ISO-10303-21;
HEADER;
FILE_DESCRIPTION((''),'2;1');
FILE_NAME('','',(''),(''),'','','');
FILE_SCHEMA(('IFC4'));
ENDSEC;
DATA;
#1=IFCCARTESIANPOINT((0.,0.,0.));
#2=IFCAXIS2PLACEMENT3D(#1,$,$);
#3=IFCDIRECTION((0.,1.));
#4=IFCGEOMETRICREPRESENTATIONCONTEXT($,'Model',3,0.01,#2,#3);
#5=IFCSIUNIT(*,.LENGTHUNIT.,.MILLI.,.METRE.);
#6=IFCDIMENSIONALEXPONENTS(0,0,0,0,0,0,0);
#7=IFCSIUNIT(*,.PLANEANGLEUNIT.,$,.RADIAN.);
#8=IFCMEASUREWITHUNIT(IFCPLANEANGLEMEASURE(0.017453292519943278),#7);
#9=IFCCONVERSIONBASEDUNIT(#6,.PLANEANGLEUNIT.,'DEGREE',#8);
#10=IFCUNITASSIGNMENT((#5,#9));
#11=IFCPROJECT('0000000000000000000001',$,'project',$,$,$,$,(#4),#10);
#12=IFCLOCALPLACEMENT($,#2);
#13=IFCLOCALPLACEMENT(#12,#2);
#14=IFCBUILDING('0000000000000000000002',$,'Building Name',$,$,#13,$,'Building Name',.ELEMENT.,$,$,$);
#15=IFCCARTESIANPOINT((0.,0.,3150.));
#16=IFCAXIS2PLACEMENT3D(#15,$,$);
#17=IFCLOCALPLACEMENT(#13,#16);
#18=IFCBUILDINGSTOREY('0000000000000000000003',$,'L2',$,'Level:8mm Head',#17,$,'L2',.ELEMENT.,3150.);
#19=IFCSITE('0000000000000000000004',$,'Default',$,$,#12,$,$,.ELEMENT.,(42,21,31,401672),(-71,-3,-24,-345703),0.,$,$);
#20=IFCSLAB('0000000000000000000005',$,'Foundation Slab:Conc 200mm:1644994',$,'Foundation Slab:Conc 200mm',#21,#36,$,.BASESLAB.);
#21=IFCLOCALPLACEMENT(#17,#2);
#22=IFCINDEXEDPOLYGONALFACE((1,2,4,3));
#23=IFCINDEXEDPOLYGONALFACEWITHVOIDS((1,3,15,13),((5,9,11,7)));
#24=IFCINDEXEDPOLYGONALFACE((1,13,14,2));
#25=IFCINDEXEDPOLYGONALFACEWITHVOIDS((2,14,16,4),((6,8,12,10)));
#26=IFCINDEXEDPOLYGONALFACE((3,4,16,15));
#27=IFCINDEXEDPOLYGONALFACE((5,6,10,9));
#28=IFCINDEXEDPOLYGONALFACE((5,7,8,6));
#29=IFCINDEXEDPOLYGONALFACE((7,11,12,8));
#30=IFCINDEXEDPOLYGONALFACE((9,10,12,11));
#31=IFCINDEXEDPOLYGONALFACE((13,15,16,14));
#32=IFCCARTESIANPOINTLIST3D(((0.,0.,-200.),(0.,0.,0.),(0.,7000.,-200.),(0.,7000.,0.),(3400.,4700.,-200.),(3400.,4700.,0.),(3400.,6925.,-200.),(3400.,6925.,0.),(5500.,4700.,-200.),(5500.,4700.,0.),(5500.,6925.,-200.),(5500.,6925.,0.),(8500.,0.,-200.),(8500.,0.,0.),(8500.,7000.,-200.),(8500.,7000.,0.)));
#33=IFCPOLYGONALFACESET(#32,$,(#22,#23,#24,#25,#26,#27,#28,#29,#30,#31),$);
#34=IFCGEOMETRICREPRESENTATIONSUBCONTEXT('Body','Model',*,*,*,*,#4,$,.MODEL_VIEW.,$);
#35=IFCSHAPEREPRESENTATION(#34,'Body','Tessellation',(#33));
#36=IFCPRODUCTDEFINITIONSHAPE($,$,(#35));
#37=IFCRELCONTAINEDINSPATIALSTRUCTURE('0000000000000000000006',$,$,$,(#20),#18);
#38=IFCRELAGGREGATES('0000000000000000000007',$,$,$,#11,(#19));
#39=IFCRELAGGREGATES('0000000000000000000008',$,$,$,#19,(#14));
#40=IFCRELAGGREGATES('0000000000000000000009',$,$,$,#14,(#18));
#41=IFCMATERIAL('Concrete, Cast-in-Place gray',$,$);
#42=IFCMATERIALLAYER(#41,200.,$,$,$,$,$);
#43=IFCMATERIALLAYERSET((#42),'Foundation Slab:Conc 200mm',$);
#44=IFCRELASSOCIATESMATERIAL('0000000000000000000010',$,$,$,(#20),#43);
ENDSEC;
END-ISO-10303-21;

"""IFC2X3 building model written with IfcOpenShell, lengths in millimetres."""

from ifc_helpers import new_model, entity, si_unit, converted_unit, direction, frame, frame_2d, origin, origin_2d_with_axis, place, context, subcontext, project, spatial, rectangle, extrude, material, layer, layer_set, layer_usage, element, save


model = new_model("IFC2X3")

# Units and contexts
model_context = context("Model", 3, precision=0.01, world=origin(), true_north=direction((0.0, 1.0)))
body_context = subcontext(model_context, "Body", "Model", "MODEL_VIEW")
ifc_project = project(units=[si_unit("LENGTHUNIT", "METRE", prefix="MILLI"), converted_unit("PLANEANGLEUNIT", "DEGREE", entity("IfcPlaneAngleMeasure", 0.017453292519943278), si_unit("PLANEANGLEUNIT", "RADIAN"), dimensions=[0, 0, 0, 0, 0, 0, 0])], contexts=[model_context])

# Site, building, storey
site_placement = place(None, origin())
site = spatial("IfcSite", under=ifc_project, at=site_placement, Name="Default", CompositionType="ELEMENT", RefLatitude=(42, 21, 31, 401672), RefLongitude=(-71, -3, -24, -345703), RefElevation=0.0)
building_placement = place(site_placement, origin())
building = spatial("IfcBuilding", under=site, at=building_placement, Name="Building Name", LongName="Building Name", CompositionType="ELEMENT")
storey_placement = place(building_placement, frame((0.0, 0.0, 3150.0)))
storey = spatial("IfcBuildingStorey", under=building, at=storey_placement, Name="L2", ObjectType="Level:8mm Head", LongName="L2", CompositionType="ELEMENT", Elevation=3150.0)

# Slab, opening
ifc_material = material(Name="Concrete, Cast-in-Place gray")
ifc_layer = layer(ifc_material, 200.0)
ifc_layer_set = layer_set([ifc_layer], Name="Foundation Slab:Conc 200mm")
ifc_layer_usage = layer_usage(ifc_layer_set, "AXIS3", "POSITIVE", 0.0)
slab_placement = place(storey_placement, frame((0.0, 0.0, -200.0)))
slab = element("IfcSlab", 1, at=slab_placement, inside=storey, material=ifc_layer_usage, Name="Foundation Slab:Conc 200mm:1644994", ObjectType="Foundation Slab:Conc 200mm", PredefinedType="BASESLAB", context=body_context, shape_type="SweptSolid", body=[
    extrude(rectangle(XDim=8500.0, YDim=7000.0, at=origin_2d_with_axis()), frame((4250.0, 3500.0, 200.0), z_axis=(0.0, 0.0, -1.0), x_axis=(-1.0, 0.0, 0.0)), (0.0, 0.0, 1.0), 200.0),
])
opening_placement = place(slab_placement, origin())
element("IfcOpeningElement", 2, at=opening_placement, cuts=slab, ObjectType="Opening", context=body_context, shape_type="SweptSolid", body=[
    extrude(rectangle(XDim=2225.0, YDim=2100.0, at=frame_2d((0.0, 0.0), x_axis=(1.0, 0.0))), frame((4450.0, 5812.5, 0.0), z_axis=(0.0, 0.0, 1.0), x_axis=(0.0, 1.0, 0.0)), (0.0, 0.0, 1.0), 200.0),
])

save(model, "model.ifc")
